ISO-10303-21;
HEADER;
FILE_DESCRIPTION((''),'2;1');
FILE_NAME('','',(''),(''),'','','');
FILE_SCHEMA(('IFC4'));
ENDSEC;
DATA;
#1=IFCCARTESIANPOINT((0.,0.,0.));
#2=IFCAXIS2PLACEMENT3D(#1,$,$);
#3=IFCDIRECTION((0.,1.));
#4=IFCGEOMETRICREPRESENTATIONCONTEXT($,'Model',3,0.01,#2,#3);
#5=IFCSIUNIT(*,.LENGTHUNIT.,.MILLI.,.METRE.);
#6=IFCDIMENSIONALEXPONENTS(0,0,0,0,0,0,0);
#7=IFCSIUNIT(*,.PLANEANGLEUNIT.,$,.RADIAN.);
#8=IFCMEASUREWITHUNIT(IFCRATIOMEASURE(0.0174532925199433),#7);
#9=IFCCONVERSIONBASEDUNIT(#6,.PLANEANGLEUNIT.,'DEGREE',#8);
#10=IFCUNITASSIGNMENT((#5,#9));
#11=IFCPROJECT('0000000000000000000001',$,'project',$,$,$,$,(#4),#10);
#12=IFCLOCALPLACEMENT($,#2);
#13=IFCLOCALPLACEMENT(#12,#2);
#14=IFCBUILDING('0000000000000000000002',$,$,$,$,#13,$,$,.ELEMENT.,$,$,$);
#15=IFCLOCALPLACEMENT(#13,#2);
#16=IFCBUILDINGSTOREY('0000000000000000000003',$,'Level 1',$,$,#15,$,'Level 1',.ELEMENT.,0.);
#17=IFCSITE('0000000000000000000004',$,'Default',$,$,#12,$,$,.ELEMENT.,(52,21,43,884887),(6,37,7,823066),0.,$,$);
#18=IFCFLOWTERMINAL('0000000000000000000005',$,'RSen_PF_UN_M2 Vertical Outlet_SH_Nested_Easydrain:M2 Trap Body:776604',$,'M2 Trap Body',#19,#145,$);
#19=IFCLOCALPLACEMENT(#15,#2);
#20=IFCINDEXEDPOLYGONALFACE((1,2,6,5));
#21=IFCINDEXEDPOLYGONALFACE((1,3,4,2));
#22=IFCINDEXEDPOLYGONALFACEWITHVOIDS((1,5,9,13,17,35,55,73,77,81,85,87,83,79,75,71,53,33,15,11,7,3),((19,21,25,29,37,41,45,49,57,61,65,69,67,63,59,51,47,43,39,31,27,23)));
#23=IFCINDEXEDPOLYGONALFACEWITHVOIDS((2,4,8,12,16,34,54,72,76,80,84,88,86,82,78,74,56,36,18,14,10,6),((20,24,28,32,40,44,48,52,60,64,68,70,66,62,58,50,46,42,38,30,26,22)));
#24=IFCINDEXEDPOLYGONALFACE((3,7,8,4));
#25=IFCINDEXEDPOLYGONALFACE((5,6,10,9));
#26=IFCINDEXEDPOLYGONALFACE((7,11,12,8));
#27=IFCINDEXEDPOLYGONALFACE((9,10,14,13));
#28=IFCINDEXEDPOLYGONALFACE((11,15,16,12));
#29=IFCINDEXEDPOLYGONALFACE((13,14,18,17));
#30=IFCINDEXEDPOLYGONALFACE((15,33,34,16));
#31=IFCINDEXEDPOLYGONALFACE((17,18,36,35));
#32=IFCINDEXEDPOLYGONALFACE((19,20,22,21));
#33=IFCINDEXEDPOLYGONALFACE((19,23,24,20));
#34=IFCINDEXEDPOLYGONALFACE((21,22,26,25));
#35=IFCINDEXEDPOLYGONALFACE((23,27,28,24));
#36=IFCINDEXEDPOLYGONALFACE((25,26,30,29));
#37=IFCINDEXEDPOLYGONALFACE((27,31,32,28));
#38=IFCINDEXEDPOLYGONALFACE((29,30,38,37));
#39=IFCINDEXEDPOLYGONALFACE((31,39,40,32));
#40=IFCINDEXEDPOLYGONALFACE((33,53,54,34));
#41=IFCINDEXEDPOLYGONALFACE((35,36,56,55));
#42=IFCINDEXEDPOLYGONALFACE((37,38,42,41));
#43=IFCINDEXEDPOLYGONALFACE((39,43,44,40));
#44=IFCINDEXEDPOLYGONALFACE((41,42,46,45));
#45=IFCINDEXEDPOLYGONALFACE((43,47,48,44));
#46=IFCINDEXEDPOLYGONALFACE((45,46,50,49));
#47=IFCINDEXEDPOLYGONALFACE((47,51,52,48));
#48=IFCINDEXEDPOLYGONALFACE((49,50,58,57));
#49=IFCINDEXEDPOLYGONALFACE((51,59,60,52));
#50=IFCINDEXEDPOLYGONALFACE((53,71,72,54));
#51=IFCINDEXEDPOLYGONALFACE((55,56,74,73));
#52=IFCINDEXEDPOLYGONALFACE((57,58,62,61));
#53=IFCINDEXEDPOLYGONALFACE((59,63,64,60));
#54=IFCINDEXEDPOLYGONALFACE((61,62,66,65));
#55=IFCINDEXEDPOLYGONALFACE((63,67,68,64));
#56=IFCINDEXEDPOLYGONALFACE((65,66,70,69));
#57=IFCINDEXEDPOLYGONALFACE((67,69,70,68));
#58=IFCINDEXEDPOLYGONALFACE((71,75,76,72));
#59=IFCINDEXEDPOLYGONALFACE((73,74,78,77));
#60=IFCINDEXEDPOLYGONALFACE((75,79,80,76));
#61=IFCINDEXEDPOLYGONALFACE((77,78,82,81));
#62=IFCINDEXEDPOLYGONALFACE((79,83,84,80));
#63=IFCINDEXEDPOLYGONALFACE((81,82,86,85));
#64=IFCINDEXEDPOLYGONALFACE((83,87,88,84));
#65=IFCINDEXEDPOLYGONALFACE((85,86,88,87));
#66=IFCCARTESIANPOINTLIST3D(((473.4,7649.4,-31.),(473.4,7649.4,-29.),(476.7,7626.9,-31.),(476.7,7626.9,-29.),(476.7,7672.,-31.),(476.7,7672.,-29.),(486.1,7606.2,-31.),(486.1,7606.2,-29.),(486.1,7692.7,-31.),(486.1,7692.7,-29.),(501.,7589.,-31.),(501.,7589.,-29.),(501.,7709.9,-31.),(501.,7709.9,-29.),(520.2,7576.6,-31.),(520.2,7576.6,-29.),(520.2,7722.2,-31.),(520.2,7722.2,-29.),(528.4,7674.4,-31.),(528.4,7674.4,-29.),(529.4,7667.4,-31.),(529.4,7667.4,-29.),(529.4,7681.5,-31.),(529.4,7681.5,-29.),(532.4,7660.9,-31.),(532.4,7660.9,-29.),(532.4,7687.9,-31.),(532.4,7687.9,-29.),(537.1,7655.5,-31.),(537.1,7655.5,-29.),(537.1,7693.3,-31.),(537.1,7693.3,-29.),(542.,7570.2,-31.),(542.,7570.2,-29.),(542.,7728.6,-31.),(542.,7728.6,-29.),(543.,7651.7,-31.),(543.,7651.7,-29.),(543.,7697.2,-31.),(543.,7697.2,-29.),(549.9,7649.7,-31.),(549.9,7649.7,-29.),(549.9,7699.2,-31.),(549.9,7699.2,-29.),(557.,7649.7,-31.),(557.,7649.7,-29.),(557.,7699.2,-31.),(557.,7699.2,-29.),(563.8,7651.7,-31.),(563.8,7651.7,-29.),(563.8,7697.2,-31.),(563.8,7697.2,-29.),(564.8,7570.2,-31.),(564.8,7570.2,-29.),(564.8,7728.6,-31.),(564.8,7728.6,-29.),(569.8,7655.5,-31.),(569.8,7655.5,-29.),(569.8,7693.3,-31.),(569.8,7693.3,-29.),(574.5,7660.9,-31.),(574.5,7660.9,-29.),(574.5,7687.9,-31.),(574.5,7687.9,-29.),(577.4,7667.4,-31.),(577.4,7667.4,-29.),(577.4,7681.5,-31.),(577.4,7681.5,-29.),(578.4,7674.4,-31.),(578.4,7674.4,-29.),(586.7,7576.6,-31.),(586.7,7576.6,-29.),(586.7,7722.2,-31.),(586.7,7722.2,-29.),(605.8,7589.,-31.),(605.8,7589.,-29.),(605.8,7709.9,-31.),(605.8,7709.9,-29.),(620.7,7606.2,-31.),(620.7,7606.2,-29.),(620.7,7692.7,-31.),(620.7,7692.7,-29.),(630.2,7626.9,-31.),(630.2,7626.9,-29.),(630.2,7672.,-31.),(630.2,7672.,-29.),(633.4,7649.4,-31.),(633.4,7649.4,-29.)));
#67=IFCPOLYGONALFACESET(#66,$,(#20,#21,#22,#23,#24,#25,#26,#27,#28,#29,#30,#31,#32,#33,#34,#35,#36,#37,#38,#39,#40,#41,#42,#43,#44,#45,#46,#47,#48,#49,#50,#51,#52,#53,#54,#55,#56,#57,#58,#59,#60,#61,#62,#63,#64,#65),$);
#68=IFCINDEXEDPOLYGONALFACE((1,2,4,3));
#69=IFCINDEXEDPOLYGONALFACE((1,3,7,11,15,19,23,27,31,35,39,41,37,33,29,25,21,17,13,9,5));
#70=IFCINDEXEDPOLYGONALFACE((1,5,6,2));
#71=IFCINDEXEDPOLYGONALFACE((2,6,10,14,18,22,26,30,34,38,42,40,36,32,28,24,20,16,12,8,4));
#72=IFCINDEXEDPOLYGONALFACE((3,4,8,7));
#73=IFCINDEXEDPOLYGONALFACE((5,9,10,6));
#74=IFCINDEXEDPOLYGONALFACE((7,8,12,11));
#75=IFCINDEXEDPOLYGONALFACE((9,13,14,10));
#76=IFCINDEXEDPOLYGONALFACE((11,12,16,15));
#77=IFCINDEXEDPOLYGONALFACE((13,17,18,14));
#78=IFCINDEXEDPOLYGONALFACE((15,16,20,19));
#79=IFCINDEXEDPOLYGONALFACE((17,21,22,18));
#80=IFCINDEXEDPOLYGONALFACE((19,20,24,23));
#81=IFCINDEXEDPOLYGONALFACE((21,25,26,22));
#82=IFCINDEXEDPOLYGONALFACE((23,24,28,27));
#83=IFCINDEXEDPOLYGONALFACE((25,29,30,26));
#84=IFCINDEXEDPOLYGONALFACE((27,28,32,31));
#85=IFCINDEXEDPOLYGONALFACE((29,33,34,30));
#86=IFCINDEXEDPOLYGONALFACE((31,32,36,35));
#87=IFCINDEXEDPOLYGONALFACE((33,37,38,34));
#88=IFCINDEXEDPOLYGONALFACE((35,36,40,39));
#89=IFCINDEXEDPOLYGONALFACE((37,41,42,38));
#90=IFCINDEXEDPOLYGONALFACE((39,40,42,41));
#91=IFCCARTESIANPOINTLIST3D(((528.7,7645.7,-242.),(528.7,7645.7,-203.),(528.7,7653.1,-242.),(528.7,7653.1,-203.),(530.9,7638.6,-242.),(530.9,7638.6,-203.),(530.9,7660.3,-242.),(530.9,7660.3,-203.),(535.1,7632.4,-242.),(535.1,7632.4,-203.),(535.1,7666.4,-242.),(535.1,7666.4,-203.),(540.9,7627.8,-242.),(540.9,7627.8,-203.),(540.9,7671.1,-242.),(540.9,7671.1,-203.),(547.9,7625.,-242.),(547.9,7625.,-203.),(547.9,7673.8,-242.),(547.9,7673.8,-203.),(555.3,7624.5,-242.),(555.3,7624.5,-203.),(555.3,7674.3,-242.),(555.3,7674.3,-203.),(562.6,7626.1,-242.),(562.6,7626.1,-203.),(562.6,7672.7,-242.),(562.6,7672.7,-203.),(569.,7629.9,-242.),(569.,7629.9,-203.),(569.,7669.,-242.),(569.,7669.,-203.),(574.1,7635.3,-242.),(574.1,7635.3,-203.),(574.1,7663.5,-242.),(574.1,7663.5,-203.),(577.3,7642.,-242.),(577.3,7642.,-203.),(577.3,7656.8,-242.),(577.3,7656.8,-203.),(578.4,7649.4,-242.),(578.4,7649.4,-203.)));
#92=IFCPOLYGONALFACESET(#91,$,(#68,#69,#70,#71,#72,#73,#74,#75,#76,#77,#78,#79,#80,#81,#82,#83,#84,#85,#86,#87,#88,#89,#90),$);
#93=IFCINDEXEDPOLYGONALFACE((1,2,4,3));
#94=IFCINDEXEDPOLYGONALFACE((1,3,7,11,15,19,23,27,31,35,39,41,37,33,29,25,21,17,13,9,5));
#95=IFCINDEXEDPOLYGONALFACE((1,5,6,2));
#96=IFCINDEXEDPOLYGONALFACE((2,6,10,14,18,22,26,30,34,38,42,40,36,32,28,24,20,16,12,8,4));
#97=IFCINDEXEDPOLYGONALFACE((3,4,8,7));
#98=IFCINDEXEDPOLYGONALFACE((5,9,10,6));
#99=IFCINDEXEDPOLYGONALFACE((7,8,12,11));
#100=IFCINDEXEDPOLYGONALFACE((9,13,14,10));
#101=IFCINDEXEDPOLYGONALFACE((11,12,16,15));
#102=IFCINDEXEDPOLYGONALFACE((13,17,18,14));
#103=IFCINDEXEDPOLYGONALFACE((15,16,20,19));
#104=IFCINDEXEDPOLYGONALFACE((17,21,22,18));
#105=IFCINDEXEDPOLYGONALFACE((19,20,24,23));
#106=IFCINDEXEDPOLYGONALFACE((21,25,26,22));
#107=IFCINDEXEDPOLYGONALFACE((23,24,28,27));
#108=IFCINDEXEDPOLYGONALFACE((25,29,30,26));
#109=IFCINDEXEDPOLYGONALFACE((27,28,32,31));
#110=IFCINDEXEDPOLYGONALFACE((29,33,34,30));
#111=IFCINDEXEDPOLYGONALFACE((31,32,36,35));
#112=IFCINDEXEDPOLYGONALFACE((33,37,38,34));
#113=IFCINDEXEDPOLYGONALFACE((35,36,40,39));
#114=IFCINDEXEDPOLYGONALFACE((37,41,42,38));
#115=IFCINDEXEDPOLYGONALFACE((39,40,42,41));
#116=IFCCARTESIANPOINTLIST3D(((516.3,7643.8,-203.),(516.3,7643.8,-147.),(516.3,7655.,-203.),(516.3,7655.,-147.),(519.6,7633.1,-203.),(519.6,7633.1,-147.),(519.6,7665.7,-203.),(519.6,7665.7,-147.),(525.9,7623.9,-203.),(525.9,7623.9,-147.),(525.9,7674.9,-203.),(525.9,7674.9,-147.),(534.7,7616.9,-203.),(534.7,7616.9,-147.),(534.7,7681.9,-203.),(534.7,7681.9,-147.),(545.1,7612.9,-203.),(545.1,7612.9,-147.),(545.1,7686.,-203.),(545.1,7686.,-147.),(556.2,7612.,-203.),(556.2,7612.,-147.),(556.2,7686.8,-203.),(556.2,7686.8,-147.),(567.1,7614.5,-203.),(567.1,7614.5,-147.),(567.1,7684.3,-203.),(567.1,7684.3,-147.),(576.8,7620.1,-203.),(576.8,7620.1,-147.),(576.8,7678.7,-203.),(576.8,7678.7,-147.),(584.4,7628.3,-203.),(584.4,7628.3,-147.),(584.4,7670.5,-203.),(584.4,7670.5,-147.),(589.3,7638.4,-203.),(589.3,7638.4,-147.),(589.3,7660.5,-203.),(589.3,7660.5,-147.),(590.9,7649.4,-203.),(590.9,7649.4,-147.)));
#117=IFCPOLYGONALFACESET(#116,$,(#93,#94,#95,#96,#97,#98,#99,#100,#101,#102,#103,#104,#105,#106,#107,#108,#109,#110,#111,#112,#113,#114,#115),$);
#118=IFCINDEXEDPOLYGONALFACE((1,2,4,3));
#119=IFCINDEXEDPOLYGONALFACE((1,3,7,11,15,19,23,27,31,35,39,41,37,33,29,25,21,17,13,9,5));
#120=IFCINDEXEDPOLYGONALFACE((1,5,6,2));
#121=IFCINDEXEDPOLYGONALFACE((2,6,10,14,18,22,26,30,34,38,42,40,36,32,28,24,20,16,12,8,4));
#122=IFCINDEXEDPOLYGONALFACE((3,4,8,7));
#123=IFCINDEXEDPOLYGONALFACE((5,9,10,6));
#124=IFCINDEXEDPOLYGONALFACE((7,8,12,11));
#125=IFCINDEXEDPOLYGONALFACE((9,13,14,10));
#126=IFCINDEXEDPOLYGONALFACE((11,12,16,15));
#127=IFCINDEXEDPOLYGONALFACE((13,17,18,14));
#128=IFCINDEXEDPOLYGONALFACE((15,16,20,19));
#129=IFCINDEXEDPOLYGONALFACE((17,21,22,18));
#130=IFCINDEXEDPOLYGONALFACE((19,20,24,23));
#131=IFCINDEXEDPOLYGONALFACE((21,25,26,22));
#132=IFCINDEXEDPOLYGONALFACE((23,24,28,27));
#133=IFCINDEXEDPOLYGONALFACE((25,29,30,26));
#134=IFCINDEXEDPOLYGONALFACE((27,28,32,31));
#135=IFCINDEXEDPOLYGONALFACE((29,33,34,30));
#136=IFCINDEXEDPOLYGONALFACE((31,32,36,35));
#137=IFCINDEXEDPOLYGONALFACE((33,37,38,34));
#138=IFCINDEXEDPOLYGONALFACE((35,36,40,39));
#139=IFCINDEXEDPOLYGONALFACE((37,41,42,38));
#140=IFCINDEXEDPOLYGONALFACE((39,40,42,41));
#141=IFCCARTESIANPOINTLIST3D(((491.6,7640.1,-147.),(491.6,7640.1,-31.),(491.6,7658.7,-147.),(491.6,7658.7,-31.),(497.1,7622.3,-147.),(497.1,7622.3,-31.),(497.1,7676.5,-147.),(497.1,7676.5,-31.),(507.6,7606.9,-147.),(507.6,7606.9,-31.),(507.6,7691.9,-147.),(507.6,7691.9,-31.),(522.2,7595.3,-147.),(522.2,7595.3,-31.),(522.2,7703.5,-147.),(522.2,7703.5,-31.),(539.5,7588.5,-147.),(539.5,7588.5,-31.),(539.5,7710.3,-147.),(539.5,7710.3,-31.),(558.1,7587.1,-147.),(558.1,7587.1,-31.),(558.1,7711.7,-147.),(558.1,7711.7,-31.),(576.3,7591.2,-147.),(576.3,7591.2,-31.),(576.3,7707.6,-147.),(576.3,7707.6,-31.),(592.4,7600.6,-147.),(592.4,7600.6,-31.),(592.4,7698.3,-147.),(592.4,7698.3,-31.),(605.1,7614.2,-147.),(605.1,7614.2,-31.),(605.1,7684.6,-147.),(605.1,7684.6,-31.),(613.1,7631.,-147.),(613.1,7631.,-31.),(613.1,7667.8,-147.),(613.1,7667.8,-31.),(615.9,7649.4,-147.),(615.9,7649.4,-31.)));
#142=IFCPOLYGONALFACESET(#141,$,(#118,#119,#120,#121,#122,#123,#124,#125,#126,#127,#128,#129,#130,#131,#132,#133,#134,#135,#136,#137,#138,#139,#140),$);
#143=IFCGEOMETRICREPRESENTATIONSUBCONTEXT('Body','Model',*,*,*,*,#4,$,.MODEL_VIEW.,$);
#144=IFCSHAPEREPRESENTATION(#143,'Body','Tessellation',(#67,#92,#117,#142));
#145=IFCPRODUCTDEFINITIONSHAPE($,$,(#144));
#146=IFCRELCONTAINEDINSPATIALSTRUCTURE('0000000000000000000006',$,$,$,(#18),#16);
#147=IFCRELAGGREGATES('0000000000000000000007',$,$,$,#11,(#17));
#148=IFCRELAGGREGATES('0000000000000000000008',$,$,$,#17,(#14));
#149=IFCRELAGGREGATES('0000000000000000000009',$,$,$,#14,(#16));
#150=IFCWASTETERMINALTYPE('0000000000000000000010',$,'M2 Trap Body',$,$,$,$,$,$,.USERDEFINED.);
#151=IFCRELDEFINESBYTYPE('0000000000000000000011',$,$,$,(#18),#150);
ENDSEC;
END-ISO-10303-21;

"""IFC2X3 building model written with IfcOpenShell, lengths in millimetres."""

from ifc_helpers import new_model, entity, si_unit, converted_unit, direction, frame, frame_2d, origin, origin_2d_with_axis, place, context, subcontext, project, spatial, circle_curve, parameter, trimmed, segment, composite_curve, circle, outline, extrude, source, transform, mapped, type_object, type_shapes, element, save


model = new_model("IFC2X3")

# Units and contexts
model_context = context("Model", 3, precision=0.01, world=origin(), true_north=direction((0.0, 1.0)))
body_context = subcontext(model_context, "Body", "Model", "MODEL_VIEW")
ifc_project = project(units=[si_unit("LENGTHUNIT", "METRE", prefix="MILLI"), converted_unit("PLANEANGLEUNIT", "DEGREE", entity("IfcRatioMeasure", 0.0174532925199433), si_unit("PLANEANGLEUNIT", "RADIAN"), dimensions=[0, 0, 0, 0, 0, 0, 0])], contexts=[model_context])

# Site, building, storey
site_placement = place(None, origin())
site = spatial("IfcSite", under=ifc_project, at=site_placement, Name="Default", CompositionType="ELEMENT", RefLatitude=(52, 21, 43, 884887), RefLongitude=(6, 37, 7, 823066), RefElevation=0.0)
building_placement = place(site_placement, origin())
building = spatial("IfcBuilding", under=site, at=building_placement, CompositionType="ELEMENT")
storey_placement = place(building_placement, origin())
storey = spatial("IfcBuildingStorey", under=building, at=storey_placement, Name="Level 1", LongName="Level 1", CompositionType="ELEMENT", Elevation=0.0)

# Flow terminal
waste_terminal_type_1 = type_object("IfcWasteTerminalType", Name="M2 Trap Body", PredefinedType="USERDEFINED")
shared_shape_1 = source(origin(), body_context, "Body", "SweptSolid", [
    extrude(outline(composite_curve([segment(trimmed(circle_curve(origin_2d_with_axis(), 80.0), [parameter(0.0)], [parameter(180.0)], True, "PARAMETER"), True, "CONTINUOUS"), segment(trimmed(circle_curve(origin_2d_with_axis(), 80.0), [parameter(180.0)], [parameter(360.0)], True, "PARAMETER"), True, "CONTINUOUS")], self_intersect=False), holes=[composite_curve([segment(trimmed(circle_curve(frame_2d((0.0, 25.0), x_axis=(1.0, 0.0)), 25.0), [parameter(180.0)], [parameter(360.0)], True, "PARAMETER"), False, "CONTINUOUS"), segment(trimmed(circle_curve(frame_2d((0.0, 25.0), x_axis=(1.0, 0.0)), 25.0), [parameter(0.0)], [parameter(180.0)], True, "PARAMETER"), False, "CONTINUOUS")], self_intersect=False)]), frame((0.0, -25.0, -2.0)), (0.0, 0.0, 1.0), 2.0),
    extrude(circle(Radius=25.0, at=frame_2d((0.0, 0.0), x_axis=(1.0, 0.0))), frame((0.0, -25.0, -213.0)), (0.0, 0.0, 1.0), 39.0),
    extrude(circle(Radius=37.5, at=frame_2d((0.0, 0.0), x_axis=(1.0, 0.0))), frame((0.0, -25.0, -174.0)), (0.0, 0.0, 1.0), 56.0),
    extrude(circle(Radius=62.5, at=frame_2d((0.0, 0.0), x_axis=(1.0, 0.0))), frame((0.0, -25.0, -118.0)), (0.0, 0.0, 1.0), 116.0),
])
type_shapes(waste_terminal_type_1, [shared_shape_1])
for number, where, name in (
    (1, (553.4, 7674.4, -29.0), "RSen_PF_UN_M2 Vertical Outlet_SH_Nested_Easydrain:M2 Trap Body:776604"),
):
    element("IfcFlowTerminal", number, at=place(storey_placement, frame(where)), inside=storey, type_object=waste_terminal_type_1, Name=name, ObjectType="M2 Trap Body", context=body_context, shape_type="MappedRepresentation", body=[
        mapped(shared_shape_1, transform((0.0, 0.0, 0.0), scale=1.0)),
    ])

save(model, "model.ifc")
